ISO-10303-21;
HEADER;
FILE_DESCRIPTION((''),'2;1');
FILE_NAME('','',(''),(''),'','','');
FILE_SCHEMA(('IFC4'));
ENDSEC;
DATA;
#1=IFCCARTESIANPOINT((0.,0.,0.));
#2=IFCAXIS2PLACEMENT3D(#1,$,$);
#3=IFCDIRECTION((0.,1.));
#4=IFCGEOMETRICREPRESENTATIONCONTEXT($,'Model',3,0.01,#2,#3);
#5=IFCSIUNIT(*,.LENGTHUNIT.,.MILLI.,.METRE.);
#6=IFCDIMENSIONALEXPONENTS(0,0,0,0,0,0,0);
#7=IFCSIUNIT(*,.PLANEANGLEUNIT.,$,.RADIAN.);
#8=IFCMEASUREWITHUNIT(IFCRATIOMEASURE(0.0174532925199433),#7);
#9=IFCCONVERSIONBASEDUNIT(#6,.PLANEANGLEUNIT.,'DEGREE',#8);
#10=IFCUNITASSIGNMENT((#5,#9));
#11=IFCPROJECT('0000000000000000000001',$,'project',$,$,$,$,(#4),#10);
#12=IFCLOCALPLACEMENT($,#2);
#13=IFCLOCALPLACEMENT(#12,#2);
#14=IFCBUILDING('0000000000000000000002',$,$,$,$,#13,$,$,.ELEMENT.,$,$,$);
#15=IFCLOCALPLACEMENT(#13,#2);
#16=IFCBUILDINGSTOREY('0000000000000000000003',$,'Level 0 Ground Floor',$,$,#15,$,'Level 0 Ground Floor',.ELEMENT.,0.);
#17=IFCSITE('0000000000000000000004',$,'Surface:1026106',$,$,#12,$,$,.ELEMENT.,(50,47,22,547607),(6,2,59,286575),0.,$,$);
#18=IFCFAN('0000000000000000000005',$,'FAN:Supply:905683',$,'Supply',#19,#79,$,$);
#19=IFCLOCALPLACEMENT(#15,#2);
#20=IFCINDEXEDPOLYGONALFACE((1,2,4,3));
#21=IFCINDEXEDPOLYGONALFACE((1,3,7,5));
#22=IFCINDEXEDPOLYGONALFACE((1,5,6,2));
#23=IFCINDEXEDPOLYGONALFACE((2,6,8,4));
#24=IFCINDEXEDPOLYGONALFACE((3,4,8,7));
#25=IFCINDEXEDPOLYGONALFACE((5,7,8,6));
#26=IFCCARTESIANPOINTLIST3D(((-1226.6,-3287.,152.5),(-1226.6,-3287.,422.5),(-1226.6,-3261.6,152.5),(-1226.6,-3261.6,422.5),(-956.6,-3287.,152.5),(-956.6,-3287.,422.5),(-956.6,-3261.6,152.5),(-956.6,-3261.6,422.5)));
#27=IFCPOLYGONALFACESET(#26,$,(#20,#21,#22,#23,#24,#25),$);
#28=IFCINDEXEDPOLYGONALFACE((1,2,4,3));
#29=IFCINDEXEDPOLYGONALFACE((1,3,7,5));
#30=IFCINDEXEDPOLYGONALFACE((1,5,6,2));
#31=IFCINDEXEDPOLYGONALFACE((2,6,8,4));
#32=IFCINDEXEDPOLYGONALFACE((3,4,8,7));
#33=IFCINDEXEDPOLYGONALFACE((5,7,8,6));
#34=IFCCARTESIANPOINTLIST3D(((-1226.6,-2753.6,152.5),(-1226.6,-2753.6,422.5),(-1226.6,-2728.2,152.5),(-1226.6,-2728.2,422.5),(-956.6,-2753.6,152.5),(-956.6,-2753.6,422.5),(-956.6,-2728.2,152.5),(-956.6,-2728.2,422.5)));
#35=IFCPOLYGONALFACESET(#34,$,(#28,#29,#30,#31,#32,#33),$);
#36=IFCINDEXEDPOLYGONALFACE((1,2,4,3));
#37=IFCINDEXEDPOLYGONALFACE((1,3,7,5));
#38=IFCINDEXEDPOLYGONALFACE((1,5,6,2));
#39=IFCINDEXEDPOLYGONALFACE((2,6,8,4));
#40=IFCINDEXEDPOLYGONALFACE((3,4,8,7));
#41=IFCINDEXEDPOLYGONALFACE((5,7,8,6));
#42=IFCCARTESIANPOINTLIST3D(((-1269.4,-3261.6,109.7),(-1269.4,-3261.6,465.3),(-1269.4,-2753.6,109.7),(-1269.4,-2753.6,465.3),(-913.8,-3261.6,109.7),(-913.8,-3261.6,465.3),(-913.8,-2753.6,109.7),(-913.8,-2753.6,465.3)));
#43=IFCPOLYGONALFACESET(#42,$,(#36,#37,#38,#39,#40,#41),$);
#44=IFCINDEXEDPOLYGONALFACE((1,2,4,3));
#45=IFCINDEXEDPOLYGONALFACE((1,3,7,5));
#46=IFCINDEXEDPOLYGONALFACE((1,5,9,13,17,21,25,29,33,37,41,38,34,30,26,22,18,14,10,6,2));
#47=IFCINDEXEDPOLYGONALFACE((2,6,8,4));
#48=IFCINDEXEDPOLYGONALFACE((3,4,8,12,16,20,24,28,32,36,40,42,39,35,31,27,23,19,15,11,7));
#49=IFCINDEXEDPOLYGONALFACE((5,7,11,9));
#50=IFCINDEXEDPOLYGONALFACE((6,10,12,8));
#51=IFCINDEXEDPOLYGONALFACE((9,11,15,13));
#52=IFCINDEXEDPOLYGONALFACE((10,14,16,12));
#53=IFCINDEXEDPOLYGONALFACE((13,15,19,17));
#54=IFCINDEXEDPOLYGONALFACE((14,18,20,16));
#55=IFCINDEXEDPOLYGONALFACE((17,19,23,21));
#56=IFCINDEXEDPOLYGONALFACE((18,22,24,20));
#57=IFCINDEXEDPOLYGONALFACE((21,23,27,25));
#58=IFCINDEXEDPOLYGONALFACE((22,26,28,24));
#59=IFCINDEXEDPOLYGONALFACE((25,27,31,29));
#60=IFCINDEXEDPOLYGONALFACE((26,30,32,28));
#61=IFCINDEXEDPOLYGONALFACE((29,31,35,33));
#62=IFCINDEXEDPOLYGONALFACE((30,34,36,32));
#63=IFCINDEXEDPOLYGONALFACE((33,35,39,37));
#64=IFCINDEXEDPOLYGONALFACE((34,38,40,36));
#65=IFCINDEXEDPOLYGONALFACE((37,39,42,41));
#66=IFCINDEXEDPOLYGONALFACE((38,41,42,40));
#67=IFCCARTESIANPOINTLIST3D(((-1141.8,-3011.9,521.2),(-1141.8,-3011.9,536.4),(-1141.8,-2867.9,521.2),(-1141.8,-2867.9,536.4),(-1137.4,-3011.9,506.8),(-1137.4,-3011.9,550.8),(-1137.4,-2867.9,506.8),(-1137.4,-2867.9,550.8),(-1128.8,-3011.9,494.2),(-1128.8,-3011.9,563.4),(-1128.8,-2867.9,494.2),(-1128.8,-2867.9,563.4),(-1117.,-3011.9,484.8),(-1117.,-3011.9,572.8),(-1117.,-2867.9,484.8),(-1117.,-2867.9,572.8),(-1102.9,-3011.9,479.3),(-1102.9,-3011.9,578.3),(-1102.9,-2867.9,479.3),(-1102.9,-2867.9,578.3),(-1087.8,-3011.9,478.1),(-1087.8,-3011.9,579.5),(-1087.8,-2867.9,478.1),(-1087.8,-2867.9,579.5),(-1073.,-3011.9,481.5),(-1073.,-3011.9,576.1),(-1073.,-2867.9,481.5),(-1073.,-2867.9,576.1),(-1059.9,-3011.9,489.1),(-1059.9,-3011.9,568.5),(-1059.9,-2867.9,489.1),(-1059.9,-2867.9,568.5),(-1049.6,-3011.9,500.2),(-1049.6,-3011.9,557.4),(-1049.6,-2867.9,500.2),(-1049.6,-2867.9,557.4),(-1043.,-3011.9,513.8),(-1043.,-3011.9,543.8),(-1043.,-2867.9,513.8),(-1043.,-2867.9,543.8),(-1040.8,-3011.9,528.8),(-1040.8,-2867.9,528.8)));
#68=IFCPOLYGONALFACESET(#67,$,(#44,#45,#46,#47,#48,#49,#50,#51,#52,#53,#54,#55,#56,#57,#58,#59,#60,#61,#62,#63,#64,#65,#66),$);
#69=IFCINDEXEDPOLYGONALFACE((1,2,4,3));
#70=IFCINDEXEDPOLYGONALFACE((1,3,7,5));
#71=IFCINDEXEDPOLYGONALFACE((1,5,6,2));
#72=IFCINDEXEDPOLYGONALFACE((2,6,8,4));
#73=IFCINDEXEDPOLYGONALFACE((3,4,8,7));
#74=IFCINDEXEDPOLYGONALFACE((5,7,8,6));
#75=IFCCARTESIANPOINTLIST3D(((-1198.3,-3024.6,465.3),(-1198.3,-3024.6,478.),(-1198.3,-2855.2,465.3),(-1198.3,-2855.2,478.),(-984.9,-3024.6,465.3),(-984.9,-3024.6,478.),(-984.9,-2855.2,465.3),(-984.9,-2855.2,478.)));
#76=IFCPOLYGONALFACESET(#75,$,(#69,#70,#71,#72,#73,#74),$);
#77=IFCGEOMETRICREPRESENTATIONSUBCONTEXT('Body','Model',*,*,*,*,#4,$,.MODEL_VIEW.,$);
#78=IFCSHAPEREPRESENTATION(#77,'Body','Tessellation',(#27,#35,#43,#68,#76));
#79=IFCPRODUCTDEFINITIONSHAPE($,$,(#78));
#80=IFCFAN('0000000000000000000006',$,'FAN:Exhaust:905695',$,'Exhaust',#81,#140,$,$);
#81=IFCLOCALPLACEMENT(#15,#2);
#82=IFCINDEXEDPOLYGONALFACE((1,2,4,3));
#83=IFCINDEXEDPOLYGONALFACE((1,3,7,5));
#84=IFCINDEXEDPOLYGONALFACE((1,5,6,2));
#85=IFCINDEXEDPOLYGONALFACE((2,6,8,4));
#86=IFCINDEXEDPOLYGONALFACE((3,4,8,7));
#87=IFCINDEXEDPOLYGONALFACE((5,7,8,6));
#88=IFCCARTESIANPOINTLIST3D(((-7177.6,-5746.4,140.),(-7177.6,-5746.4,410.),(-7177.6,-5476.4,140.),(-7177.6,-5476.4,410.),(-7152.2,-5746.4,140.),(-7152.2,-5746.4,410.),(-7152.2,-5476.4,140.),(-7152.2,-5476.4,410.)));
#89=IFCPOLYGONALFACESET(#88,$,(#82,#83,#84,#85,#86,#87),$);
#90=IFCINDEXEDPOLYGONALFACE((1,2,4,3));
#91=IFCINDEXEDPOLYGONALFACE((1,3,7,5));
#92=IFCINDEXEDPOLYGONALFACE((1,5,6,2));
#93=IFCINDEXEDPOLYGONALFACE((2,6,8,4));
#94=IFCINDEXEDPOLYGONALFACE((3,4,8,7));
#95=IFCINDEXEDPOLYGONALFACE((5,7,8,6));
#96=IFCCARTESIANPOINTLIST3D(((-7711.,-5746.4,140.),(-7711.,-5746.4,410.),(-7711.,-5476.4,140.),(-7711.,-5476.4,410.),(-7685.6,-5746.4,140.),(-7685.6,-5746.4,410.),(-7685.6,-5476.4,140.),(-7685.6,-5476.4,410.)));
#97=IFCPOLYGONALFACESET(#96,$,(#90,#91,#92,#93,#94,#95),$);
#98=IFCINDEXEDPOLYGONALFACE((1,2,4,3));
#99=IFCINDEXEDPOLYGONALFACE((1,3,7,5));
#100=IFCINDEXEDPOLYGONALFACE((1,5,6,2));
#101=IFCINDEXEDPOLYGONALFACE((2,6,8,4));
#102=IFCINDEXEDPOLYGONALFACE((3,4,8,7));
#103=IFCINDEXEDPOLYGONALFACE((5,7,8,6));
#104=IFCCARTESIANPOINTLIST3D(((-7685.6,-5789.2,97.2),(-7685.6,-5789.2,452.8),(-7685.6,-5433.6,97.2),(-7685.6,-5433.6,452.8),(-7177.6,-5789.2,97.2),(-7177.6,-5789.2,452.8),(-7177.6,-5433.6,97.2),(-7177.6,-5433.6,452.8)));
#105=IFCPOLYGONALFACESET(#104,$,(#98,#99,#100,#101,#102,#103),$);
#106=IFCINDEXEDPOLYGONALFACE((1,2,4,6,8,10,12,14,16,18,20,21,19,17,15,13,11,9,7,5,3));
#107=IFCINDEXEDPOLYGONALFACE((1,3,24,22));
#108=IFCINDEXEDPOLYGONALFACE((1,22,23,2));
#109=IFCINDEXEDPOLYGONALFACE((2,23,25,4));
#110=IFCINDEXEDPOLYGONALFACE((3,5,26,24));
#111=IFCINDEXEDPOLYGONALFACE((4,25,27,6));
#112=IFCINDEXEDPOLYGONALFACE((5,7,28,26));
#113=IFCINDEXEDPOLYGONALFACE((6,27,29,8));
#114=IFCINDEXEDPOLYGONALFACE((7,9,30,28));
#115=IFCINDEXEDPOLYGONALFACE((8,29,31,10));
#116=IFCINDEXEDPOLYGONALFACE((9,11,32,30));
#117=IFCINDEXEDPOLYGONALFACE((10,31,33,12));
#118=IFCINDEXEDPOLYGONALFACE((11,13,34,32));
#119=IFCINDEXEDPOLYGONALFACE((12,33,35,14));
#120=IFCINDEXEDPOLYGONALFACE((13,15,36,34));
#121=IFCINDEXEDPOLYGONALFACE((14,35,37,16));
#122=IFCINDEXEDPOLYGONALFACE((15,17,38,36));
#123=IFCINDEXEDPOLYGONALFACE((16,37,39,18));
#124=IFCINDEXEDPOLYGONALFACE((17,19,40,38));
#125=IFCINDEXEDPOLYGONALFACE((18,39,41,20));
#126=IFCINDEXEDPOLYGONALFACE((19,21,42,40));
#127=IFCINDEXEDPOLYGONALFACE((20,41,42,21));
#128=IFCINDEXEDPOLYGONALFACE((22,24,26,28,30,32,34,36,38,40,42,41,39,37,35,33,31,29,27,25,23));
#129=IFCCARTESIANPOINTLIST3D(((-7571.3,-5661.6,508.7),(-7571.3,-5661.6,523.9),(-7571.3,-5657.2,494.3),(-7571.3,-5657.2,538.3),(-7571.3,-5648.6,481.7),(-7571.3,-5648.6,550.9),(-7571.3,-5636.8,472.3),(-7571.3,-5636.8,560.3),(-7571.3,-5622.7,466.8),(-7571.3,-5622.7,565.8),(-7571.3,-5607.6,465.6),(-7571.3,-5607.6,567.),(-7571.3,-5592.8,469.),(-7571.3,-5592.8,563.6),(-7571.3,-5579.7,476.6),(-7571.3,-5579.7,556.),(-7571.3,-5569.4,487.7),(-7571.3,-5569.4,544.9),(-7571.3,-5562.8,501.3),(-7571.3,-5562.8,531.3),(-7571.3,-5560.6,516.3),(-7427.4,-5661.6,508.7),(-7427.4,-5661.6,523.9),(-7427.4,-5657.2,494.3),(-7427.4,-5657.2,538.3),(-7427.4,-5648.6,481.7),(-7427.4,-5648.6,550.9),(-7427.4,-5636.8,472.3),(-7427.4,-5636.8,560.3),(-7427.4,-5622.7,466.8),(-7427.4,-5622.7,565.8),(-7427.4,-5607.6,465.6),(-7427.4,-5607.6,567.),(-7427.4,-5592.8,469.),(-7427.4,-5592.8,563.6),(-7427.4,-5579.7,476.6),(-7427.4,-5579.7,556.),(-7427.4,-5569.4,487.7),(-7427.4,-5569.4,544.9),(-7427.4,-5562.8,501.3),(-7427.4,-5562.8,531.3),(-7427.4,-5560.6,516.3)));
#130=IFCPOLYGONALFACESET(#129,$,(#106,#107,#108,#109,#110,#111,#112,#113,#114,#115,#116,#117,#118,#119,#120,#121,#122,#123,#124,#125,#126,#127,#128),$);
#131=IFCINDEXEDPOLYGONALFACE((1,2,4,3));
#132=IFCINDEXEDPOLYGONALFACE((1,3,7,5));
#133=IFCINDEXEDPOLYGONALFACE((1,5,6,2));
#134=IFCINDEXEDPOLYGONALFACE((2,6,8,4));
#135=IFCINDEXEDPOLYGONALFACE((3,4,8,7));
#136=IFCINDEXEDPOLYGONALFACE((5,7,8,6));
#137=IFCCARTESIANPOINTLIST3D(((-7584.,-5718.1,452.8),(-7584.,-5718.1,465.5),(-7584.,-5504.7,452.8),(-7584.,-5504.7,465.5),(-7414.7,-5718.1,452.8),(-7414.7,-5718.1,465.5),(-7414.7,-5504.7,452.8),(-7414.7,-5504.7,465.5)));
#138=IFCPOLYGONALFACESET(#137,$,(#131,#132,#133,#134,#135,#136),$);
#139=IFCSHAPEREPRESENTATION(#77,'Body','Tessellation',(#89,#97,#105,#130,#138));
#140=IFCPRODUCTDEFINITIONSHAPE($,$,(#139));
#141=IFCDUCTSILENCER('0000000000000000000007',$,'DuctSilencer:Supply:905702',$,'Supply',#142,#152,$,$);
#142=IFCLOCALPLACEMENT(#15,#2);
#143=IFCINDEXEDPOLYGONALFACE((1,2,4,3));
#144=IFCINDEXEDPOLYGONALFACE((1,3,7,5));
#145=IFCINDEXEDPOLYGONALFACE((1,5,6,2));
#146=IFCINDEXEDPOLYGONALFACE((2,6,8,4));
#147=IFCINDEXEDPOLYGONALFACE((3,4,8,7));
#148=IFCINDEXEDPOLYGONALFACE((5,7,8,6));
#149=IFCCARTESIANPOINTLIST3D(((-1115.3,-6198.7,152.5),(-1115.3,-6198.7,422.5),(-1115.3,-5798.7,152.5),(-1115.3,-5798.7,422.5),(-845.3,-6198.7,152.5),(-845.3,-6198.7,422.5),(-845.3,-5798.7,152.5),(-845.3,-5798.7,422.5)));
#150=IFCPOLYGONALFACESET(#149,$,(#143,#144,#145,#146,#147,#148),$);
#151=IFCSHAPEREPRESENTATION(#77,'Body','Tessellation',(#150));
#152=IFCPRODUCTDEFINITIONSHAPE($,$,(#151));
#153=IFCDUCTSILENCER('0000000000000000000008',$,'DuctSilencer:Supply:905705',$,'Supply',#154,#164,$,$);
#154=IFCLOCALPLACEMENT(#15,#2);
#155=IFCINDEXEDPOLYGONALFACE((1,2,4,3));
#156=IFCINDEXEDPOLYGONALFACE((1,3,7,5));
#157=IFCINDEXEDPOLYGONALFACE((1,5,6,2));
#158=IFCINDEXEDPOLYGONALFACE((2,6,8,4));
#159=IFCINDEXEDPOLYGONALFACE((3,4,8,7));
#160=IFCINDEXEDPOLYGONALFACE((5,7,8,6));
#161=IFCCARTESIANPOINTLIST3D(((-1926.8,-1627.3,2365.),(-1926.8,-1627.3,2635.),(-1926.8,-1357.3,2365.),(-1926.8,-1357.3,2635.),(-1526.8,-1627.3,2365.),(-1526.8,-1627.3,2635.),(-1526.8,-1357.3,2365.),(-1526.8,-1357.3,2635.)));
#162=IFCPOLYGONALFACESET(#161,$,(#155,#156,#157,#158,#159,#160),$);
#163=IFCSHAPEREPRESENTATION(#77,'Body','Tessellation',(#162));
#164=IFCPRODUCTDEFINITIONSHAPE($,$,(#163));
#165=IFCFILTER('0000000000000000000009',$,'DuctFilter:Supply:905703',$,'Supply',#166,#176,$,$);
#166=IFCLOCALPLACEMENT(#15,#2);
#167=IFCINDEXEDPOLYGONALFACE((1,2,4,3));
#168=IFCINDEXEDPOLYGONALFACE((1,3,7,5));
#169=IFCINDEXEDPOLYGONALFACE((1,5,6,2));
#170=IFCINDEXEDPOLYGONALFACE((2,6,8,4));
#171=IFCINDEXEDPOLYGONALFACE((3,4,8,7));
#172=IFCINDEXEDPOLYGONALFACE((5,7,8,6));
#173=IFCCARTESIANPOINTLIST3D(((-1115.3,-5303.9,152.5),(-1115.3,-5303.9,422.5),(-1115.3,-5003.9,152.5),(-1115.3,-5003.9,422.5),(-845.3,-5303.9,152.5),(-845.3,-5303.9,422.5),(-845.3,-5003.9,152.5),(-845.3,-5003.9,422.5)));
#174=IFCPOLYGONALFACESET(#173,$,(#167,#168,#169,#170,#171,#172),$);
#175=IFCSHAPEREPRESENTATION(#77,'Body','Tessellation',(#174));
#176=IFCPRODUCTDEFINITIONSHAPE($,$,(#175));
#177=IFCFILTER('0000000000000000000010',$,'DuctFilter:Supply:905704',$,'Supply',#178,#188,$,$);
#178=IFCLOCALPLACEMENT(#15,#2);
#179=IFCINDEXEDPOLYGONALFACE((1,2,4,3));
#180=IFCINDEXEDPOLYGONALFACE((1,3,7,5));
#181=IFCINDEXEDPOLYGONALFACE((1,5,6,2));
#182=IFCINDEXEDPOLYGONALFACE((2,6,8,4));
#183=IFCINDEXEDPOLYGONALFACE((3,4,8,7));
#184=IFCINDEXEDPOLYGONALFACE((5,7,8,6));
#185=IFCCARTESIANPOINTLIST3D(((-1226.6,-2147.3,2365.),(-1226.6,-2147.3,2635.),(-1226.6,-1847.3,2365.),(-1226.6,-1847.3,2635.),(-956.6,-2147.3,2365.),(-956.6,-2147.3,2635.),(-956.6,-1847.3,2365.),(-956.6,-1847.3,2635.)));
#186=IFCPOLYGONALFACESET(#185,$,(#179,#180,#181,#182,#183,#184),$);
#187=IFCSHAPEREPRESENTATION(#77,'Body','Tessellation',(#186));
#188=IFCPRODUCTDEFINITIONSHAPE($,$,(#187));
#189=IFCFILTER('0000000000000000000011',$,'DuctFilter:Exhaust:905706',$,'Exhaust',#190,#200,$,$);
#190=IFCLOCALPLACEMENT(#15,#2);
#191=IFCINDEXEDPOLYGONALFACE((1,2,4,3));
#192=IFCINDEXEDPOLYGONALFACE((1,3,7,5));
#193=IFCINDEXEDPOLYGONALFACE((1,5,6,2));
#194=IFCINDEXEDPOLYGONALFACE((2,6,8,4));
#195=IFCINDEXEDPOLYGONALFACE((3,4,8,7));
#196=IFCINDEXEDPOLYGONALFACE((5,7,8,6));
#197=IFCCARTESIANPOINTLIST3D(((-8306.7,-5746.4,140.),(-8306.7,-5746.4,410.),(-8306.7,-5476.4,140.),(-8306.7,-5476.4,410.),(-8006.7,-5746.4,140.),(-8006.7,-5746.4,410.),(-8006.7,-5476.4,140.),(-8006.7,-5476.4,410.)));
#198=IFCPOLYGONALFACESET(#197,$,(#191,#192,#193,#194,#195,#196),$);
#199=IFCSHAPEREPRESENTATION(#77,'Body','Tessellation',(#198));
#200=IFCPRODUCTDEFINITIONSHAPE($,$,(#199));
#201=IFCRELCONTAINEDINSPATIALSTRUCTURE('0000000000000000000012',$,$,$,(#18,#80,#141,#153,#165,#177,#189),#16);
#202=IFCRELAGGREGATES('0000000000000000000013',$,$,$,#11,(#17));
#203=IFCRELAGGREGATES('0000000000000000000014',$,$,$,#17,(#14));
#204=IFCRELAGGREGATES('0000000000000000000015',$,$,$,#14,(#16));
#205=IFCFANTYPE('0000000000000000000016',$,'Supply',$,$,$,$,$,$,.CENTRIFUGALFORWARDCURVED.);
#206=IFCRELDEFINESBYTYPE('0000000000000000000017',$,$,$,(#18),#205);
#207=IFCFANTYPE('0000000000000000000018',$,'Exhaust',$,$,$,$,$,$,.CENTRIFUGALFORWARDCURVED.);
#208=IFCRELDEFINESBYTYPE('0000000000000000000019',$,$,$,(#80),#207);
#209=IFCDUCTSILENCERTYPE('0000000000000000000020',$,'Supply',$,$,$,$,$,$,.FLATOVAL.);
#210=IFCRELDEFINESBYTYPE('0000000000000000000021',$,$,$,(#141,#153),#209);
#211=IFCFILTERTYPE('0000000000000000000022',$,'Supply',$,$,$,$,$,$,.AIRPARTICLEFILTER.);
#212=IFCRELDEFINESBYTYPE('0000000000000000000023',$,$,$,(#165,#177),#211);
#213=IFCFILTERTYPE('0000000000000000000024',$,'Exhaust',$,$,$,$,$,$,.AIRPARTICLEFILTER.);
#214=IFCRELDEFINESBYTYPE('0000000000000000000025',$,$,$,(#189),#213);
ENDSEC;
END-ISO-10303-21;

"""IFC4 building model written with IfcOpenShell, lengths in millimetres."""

from ifc_helpers import new_model, entity, si_unit, converted_unit, direction, frame, frame_2d, origin, origin_2d_with_axis, place, context, subcontext, project, spatial, rectangle, circle, extrude, source, transform, mapped, type_object, type_shapes, element, save


model = new_model("IFC4")

# Units and contexts
model_context = context("Model", 3, precision=0.01, world=origin(), true_north=direction((0.0, 1.0)))
body_context = subcontext(model_context, "Body", "Model", "MODEL_VIEW")
ifc_project = project(units=[si_unit("LENGTHUNIT", "METRE", prefix="MILLI"), converted_unit("PLANEANGLEUNIT", "DEGREE", entity("IfcRatioMeasure", 0.0174532925199433), si_unit("PLANEANGLEUNIT", "RADIAN"), dimensions=[0, 0, 0, 0, 0, 0, 0])], contexts=[model_context])

# Site, building, storey
site_placement = place(None, origin())
site = spatial("IfcSite", under=ifc_project, at=site_placement, Name="Surface:1026106", CompositionType="ELEMENT", RefLatitude=(50, 47, 22, 547607), RefLongitude=(6, 2, 59, 286575), RefElevation=0.0)
building_placement = place(site_placement, origin())
building = spatial("IfcBuilding", under=site, at=building_placement, CompositionType="ELEMENT")
storey_placement = place(building_placement, origin())
storey = spatial("IfcBuildingStorey", under=building, at=storey_placement, Name="Level 0 Ground Floor", LongName="Level 0 Ground Floor", CompositionType="ELEMENT", Elevation=0.0)

# Fans
fan_type_1 = type_object("IfcFanType", Name="Supply", PredefinedType="CENTRIFUGALFORWARDCURVED")
shared_shape_1 = source(origin(), body_context, "Body", "SweptSolid", [
    extrude(rectangle(XDim=270.0, YDim=25.4, at=origin_2d_with_axis()), frame((0.0, -520.7, 42.8), z_axis=(0.0, 0.0, 1.0), x_axis=(-1.0, 0.0, 0.0)), (0.0, 0.0, 1.0), 270.0),
    extrude(rectangle(XDim=270.0, YDim=25.4, at=frame_2d((0.0, 0.0), x_axis=(1.0, 0.0))), frame((0.0, 12.7, 42.8), z_axis=(0.0, 0.0, 1.0), x_axis=(-1.0, 0.0, 0.0)), (0.0, 0.0, 1.0), 270.0),
    extrude(rectangle(XDim=355.6, YDim=508.0, at=origin_2d_with_axis()), frame((0.0, -254.0, 0.0), z_axis=(0.0, 0.0, 1.0), x_axis=(-1.0, 0.0, 0.0)), (0.0, 0.0, 1.0), 355.6),
    extrude(circle(Radius=50.8, at=frame_2d((0.0, 0.0), x_axis=(1.0, 0.0))), frame((0.0, -258.2, 419.1), z_axis=(0.0, 1.0, 0.0), x_axis=(1.0, 0.0, 0.0)), (0.0, 0.0, 1.0), 143.9),
    extrude(rectangle(XDim=213.4, YDim=169.3, at=origin_2d_with_axis()), frame((0.0, -186.3, 355.6), z_axis=(0.0, 0.0, 1.0), x_axis=(-1.0, 0.0, 0.0)), (0.0, 0.0, 1.0), 12.7),
])
type_shapes(fan_type_1, [shared_shape_1])
fan_1_placement = place(storey_placement, frame((-1091.6, -2753.6, 109.7)))
element("IfcFan", 1, at=fan_1_placement, inside=storey, type_object=fan_type_1, Name="FAN:Supply:905683", ObjectType="Supply", context=body_context, shape_type="MappedRepresentation", body=[
    mapped(shared_shape_1, transform((0.0, 0.0, 0.0), scale=1.0)),
])
fan_type_2 = type_object("IfcFanType", Name="Exhaust", PredefinedType="CENTRIFUGALFORWARDCURVED")
shared_shape_2 = source(origin(), body_context, "Body", "SweptSolid", [
    extrude(rectangle(XDim=270.0, YDim=25.4, at=origin_2d_with_axis()), frame((0.0, -520.7, 42.8), z_axis=(0.0, 0.0, 1.0), x_axis=(-1.0, 0.0, 0.0)), (0.0, 0.0, 1.0), 270.0),
    extrude(rectangle(XDim=270.0, YDim=25.4, at=frame_2d((0.0, 0.0), x_axis=(1.0, 0.0))), frame((0.0, 12.7, 42.8), z_axis=(0.0, 0.0, 1.0), x_axis=(-1.0, 0.0, 0.0)), (0.0, 0.0, 1.0), 270.0),
    extrude(rectangle(XDim=355.6, YDim=508.0, at=origin_2d_with_axis()), frame((0.0, -254.0, 0.0), z_axis=(0.0, 0.0, 1.0), x_axis=(-1.0, 0.0, 0.0)), (0.0, 0.0, 1.0), 355.6),
    extrude(circle(Radius=50.8, at=frame_2d((0.0, 0.0), x_axis=(1.0, 0.0))), frame((0.0, -258.2, 419.1), z_axis=(0.0, 1.0, 0.0), x_axis=(1.0, 0.0, 0.0)), (0.0, 0.0, 1.0), 143.9),
    extrude(rectangle(XDim=213.4, YDim=169.3, at=origin_2d_with_axis()), frame((0.0, -186.3, 355.6), z_axis=(0.0, 0.0, 1.0), x_axis=(-1.0, 0.0, 0.0)), (0.0, 0.0, 1.0), 12.7),
])
type_shapes(fan_type_2, [shared_shape_2])
fan_2_placement = place(storey_placement, frame((-7685.6, -5611.4, 97.2), z_axis=(0.0, 0.0, 1.0), x_axis=(0.0, 1.0, 0.0)))
element("IfcFan", 2, at=fan_2_placement, inside=storey, type_object=fan_type_2, Name="FAN:Exhaust:905695", ObjectType="Exhaust", context=body_context, shape_type="MappedRepresentation", body=[
    mapped(shared_shape_2, transform((0.0, 0.0, 0.0), scale=1.0)),
])

# Duct silencers
duct_silencer_type_1 = type_object("IfcDuctSilencerType", Name="Supply", PredefinedType="FLATOVAL")
shared_shape_3 = source(origin(), body_context, "Body", "SweptSolid", [
    extrude(rectangle(XDim=400.0, YDim=270.0, at=origin_2d_with_axis()), frame((0.0, 0.0, -135.0), z_axis=(0.0, 0.0, 1.0), x_axis=(-1.0, 0.0, 0.0)), (0.0, 0.0, 1.0), 270.0),
])
type_shapes(duct_silencer_type_1, [shared_shape_3])
duct_silencer_1_placement = place(storey_placement, frame((-980.3, -5998.7, 287.5), z_axis=(0.0, 0.0, 1.0), x_axis=(0.0, 1.0, 0.0)))
element("IfcDuctSilencer", 3, at=duct_silencer_1_placement, inside=storey, type_object=duct_silencer_type_1, Name="DuctSilencer:Supply:905702", ObjectType="Supply", context=body_context, shape_type="MappedRepresentation", body=[
    mapped(shared_shape_3, transform((0.0, 0.0, 0.0), scale=1.0)),
])
duct_silencer_2_placement = place(storey_placement, frame((-1726.8, -1492.3, 2500.0)))
element("IfcDuctSilencer", 4, at=duct_silencer_2_placement, inside=storey, type_object=duct_silencer_type_1, Name="DuctSilencer:Supply:905705", ObjectType="Supply", context=body_context, shape_type="MappedRepresentation", body=[
    mapped(shared_shape_3, transform((0.0, 0.0, 0.0), scale=1.0)),
])

# Filters
filter_type_1 = type_object("IfcFilterType", Name="Supply", PredefinedType="AIRPARTICLEFILTER")
shared_shape_4 = source(origin(), body_context, "Body", "SweptSolid", [
    extrude(rectangle(XDim=300.0, YDim=270.0, at=frame_2d((0.0, 0.0), x_axis=(1.0, 0.0))), frame((0.0, 0.0, -135.0), z_axis=(0.0, 0.0, 1.0), x_axis=(-1.0, 0.0, 0.0)), (0.0, 0.0, 1.0), 270.0),
])
type_shapes(filter_type_1, [shared_shape_4])
for number, where, z_axis, x_axis, name in (
    (5, (-980.3, -5153.9, 287.5), (0.0, 0.0, 1.0), (0.0, 1.0, 0.0), "DuctFilter:Supply:905703"),
    (6, (-1091.6, -1997.3, 2500.0), (0.0, 0.0, 1.0), (0.0, 1.0, 0.0), "DuctFilter:Supply:905704"),
):
    element("IfcFilter", number, at=place(storey_placement, frame(where, z_axis=z_axis, x_axis=x_axis)), inside=storey, type_object=filter_type_1, Name=name, ObjectType="Supply", context=body_context, shape_type="MappedRepresentation", body=[
        mapped(shared_shape_4, transform((0.0, 0.0, 0.0), scale=1.0)),
    ])
filter_type_2 = type_object("IfcFilterType", Name="Exhaust", PredefinedType="AIRPARTICLEFILTER")
shared_shape_5 = source(origin(), body_context, "Body", "SweptSolid", [
    extrude(rectangle(XDim=300.0, YDim=270.0, at=frame_2d((0.0, 0.0), x_axis=(1.0, 0.0))), frame((0.0, 0.0, -135.0), z_axis=(0.0, 0.0, 1.0), x_axis=(-1.0, 0.0, 0.0)), (0.0, 0.0, 1.0), 270.0),
])
type_shapes(filter_type_2, [shared_shape_5])
ifc_filter_placement = place(storey_placement, frame((-8156.7, -5611.4, 275.0), z_axis=(0.0, 0.0, 1.0), x_axis=(-1.0, 0.0, 0.0)))
element("IfcFilter", 7, at=ifc_filter_placement, inside=storey, type_object=filter_type_2, Name="DuctFilter:Exhaust:905706", ObjectType="Exhaust", context=body_context, shape_type="MappedRepresentation", body=[
    mapped(shared_shape_5, transform((0.0, 0.0, 0.0), scale=1.0)),
])

save(model, "model.ifc")
